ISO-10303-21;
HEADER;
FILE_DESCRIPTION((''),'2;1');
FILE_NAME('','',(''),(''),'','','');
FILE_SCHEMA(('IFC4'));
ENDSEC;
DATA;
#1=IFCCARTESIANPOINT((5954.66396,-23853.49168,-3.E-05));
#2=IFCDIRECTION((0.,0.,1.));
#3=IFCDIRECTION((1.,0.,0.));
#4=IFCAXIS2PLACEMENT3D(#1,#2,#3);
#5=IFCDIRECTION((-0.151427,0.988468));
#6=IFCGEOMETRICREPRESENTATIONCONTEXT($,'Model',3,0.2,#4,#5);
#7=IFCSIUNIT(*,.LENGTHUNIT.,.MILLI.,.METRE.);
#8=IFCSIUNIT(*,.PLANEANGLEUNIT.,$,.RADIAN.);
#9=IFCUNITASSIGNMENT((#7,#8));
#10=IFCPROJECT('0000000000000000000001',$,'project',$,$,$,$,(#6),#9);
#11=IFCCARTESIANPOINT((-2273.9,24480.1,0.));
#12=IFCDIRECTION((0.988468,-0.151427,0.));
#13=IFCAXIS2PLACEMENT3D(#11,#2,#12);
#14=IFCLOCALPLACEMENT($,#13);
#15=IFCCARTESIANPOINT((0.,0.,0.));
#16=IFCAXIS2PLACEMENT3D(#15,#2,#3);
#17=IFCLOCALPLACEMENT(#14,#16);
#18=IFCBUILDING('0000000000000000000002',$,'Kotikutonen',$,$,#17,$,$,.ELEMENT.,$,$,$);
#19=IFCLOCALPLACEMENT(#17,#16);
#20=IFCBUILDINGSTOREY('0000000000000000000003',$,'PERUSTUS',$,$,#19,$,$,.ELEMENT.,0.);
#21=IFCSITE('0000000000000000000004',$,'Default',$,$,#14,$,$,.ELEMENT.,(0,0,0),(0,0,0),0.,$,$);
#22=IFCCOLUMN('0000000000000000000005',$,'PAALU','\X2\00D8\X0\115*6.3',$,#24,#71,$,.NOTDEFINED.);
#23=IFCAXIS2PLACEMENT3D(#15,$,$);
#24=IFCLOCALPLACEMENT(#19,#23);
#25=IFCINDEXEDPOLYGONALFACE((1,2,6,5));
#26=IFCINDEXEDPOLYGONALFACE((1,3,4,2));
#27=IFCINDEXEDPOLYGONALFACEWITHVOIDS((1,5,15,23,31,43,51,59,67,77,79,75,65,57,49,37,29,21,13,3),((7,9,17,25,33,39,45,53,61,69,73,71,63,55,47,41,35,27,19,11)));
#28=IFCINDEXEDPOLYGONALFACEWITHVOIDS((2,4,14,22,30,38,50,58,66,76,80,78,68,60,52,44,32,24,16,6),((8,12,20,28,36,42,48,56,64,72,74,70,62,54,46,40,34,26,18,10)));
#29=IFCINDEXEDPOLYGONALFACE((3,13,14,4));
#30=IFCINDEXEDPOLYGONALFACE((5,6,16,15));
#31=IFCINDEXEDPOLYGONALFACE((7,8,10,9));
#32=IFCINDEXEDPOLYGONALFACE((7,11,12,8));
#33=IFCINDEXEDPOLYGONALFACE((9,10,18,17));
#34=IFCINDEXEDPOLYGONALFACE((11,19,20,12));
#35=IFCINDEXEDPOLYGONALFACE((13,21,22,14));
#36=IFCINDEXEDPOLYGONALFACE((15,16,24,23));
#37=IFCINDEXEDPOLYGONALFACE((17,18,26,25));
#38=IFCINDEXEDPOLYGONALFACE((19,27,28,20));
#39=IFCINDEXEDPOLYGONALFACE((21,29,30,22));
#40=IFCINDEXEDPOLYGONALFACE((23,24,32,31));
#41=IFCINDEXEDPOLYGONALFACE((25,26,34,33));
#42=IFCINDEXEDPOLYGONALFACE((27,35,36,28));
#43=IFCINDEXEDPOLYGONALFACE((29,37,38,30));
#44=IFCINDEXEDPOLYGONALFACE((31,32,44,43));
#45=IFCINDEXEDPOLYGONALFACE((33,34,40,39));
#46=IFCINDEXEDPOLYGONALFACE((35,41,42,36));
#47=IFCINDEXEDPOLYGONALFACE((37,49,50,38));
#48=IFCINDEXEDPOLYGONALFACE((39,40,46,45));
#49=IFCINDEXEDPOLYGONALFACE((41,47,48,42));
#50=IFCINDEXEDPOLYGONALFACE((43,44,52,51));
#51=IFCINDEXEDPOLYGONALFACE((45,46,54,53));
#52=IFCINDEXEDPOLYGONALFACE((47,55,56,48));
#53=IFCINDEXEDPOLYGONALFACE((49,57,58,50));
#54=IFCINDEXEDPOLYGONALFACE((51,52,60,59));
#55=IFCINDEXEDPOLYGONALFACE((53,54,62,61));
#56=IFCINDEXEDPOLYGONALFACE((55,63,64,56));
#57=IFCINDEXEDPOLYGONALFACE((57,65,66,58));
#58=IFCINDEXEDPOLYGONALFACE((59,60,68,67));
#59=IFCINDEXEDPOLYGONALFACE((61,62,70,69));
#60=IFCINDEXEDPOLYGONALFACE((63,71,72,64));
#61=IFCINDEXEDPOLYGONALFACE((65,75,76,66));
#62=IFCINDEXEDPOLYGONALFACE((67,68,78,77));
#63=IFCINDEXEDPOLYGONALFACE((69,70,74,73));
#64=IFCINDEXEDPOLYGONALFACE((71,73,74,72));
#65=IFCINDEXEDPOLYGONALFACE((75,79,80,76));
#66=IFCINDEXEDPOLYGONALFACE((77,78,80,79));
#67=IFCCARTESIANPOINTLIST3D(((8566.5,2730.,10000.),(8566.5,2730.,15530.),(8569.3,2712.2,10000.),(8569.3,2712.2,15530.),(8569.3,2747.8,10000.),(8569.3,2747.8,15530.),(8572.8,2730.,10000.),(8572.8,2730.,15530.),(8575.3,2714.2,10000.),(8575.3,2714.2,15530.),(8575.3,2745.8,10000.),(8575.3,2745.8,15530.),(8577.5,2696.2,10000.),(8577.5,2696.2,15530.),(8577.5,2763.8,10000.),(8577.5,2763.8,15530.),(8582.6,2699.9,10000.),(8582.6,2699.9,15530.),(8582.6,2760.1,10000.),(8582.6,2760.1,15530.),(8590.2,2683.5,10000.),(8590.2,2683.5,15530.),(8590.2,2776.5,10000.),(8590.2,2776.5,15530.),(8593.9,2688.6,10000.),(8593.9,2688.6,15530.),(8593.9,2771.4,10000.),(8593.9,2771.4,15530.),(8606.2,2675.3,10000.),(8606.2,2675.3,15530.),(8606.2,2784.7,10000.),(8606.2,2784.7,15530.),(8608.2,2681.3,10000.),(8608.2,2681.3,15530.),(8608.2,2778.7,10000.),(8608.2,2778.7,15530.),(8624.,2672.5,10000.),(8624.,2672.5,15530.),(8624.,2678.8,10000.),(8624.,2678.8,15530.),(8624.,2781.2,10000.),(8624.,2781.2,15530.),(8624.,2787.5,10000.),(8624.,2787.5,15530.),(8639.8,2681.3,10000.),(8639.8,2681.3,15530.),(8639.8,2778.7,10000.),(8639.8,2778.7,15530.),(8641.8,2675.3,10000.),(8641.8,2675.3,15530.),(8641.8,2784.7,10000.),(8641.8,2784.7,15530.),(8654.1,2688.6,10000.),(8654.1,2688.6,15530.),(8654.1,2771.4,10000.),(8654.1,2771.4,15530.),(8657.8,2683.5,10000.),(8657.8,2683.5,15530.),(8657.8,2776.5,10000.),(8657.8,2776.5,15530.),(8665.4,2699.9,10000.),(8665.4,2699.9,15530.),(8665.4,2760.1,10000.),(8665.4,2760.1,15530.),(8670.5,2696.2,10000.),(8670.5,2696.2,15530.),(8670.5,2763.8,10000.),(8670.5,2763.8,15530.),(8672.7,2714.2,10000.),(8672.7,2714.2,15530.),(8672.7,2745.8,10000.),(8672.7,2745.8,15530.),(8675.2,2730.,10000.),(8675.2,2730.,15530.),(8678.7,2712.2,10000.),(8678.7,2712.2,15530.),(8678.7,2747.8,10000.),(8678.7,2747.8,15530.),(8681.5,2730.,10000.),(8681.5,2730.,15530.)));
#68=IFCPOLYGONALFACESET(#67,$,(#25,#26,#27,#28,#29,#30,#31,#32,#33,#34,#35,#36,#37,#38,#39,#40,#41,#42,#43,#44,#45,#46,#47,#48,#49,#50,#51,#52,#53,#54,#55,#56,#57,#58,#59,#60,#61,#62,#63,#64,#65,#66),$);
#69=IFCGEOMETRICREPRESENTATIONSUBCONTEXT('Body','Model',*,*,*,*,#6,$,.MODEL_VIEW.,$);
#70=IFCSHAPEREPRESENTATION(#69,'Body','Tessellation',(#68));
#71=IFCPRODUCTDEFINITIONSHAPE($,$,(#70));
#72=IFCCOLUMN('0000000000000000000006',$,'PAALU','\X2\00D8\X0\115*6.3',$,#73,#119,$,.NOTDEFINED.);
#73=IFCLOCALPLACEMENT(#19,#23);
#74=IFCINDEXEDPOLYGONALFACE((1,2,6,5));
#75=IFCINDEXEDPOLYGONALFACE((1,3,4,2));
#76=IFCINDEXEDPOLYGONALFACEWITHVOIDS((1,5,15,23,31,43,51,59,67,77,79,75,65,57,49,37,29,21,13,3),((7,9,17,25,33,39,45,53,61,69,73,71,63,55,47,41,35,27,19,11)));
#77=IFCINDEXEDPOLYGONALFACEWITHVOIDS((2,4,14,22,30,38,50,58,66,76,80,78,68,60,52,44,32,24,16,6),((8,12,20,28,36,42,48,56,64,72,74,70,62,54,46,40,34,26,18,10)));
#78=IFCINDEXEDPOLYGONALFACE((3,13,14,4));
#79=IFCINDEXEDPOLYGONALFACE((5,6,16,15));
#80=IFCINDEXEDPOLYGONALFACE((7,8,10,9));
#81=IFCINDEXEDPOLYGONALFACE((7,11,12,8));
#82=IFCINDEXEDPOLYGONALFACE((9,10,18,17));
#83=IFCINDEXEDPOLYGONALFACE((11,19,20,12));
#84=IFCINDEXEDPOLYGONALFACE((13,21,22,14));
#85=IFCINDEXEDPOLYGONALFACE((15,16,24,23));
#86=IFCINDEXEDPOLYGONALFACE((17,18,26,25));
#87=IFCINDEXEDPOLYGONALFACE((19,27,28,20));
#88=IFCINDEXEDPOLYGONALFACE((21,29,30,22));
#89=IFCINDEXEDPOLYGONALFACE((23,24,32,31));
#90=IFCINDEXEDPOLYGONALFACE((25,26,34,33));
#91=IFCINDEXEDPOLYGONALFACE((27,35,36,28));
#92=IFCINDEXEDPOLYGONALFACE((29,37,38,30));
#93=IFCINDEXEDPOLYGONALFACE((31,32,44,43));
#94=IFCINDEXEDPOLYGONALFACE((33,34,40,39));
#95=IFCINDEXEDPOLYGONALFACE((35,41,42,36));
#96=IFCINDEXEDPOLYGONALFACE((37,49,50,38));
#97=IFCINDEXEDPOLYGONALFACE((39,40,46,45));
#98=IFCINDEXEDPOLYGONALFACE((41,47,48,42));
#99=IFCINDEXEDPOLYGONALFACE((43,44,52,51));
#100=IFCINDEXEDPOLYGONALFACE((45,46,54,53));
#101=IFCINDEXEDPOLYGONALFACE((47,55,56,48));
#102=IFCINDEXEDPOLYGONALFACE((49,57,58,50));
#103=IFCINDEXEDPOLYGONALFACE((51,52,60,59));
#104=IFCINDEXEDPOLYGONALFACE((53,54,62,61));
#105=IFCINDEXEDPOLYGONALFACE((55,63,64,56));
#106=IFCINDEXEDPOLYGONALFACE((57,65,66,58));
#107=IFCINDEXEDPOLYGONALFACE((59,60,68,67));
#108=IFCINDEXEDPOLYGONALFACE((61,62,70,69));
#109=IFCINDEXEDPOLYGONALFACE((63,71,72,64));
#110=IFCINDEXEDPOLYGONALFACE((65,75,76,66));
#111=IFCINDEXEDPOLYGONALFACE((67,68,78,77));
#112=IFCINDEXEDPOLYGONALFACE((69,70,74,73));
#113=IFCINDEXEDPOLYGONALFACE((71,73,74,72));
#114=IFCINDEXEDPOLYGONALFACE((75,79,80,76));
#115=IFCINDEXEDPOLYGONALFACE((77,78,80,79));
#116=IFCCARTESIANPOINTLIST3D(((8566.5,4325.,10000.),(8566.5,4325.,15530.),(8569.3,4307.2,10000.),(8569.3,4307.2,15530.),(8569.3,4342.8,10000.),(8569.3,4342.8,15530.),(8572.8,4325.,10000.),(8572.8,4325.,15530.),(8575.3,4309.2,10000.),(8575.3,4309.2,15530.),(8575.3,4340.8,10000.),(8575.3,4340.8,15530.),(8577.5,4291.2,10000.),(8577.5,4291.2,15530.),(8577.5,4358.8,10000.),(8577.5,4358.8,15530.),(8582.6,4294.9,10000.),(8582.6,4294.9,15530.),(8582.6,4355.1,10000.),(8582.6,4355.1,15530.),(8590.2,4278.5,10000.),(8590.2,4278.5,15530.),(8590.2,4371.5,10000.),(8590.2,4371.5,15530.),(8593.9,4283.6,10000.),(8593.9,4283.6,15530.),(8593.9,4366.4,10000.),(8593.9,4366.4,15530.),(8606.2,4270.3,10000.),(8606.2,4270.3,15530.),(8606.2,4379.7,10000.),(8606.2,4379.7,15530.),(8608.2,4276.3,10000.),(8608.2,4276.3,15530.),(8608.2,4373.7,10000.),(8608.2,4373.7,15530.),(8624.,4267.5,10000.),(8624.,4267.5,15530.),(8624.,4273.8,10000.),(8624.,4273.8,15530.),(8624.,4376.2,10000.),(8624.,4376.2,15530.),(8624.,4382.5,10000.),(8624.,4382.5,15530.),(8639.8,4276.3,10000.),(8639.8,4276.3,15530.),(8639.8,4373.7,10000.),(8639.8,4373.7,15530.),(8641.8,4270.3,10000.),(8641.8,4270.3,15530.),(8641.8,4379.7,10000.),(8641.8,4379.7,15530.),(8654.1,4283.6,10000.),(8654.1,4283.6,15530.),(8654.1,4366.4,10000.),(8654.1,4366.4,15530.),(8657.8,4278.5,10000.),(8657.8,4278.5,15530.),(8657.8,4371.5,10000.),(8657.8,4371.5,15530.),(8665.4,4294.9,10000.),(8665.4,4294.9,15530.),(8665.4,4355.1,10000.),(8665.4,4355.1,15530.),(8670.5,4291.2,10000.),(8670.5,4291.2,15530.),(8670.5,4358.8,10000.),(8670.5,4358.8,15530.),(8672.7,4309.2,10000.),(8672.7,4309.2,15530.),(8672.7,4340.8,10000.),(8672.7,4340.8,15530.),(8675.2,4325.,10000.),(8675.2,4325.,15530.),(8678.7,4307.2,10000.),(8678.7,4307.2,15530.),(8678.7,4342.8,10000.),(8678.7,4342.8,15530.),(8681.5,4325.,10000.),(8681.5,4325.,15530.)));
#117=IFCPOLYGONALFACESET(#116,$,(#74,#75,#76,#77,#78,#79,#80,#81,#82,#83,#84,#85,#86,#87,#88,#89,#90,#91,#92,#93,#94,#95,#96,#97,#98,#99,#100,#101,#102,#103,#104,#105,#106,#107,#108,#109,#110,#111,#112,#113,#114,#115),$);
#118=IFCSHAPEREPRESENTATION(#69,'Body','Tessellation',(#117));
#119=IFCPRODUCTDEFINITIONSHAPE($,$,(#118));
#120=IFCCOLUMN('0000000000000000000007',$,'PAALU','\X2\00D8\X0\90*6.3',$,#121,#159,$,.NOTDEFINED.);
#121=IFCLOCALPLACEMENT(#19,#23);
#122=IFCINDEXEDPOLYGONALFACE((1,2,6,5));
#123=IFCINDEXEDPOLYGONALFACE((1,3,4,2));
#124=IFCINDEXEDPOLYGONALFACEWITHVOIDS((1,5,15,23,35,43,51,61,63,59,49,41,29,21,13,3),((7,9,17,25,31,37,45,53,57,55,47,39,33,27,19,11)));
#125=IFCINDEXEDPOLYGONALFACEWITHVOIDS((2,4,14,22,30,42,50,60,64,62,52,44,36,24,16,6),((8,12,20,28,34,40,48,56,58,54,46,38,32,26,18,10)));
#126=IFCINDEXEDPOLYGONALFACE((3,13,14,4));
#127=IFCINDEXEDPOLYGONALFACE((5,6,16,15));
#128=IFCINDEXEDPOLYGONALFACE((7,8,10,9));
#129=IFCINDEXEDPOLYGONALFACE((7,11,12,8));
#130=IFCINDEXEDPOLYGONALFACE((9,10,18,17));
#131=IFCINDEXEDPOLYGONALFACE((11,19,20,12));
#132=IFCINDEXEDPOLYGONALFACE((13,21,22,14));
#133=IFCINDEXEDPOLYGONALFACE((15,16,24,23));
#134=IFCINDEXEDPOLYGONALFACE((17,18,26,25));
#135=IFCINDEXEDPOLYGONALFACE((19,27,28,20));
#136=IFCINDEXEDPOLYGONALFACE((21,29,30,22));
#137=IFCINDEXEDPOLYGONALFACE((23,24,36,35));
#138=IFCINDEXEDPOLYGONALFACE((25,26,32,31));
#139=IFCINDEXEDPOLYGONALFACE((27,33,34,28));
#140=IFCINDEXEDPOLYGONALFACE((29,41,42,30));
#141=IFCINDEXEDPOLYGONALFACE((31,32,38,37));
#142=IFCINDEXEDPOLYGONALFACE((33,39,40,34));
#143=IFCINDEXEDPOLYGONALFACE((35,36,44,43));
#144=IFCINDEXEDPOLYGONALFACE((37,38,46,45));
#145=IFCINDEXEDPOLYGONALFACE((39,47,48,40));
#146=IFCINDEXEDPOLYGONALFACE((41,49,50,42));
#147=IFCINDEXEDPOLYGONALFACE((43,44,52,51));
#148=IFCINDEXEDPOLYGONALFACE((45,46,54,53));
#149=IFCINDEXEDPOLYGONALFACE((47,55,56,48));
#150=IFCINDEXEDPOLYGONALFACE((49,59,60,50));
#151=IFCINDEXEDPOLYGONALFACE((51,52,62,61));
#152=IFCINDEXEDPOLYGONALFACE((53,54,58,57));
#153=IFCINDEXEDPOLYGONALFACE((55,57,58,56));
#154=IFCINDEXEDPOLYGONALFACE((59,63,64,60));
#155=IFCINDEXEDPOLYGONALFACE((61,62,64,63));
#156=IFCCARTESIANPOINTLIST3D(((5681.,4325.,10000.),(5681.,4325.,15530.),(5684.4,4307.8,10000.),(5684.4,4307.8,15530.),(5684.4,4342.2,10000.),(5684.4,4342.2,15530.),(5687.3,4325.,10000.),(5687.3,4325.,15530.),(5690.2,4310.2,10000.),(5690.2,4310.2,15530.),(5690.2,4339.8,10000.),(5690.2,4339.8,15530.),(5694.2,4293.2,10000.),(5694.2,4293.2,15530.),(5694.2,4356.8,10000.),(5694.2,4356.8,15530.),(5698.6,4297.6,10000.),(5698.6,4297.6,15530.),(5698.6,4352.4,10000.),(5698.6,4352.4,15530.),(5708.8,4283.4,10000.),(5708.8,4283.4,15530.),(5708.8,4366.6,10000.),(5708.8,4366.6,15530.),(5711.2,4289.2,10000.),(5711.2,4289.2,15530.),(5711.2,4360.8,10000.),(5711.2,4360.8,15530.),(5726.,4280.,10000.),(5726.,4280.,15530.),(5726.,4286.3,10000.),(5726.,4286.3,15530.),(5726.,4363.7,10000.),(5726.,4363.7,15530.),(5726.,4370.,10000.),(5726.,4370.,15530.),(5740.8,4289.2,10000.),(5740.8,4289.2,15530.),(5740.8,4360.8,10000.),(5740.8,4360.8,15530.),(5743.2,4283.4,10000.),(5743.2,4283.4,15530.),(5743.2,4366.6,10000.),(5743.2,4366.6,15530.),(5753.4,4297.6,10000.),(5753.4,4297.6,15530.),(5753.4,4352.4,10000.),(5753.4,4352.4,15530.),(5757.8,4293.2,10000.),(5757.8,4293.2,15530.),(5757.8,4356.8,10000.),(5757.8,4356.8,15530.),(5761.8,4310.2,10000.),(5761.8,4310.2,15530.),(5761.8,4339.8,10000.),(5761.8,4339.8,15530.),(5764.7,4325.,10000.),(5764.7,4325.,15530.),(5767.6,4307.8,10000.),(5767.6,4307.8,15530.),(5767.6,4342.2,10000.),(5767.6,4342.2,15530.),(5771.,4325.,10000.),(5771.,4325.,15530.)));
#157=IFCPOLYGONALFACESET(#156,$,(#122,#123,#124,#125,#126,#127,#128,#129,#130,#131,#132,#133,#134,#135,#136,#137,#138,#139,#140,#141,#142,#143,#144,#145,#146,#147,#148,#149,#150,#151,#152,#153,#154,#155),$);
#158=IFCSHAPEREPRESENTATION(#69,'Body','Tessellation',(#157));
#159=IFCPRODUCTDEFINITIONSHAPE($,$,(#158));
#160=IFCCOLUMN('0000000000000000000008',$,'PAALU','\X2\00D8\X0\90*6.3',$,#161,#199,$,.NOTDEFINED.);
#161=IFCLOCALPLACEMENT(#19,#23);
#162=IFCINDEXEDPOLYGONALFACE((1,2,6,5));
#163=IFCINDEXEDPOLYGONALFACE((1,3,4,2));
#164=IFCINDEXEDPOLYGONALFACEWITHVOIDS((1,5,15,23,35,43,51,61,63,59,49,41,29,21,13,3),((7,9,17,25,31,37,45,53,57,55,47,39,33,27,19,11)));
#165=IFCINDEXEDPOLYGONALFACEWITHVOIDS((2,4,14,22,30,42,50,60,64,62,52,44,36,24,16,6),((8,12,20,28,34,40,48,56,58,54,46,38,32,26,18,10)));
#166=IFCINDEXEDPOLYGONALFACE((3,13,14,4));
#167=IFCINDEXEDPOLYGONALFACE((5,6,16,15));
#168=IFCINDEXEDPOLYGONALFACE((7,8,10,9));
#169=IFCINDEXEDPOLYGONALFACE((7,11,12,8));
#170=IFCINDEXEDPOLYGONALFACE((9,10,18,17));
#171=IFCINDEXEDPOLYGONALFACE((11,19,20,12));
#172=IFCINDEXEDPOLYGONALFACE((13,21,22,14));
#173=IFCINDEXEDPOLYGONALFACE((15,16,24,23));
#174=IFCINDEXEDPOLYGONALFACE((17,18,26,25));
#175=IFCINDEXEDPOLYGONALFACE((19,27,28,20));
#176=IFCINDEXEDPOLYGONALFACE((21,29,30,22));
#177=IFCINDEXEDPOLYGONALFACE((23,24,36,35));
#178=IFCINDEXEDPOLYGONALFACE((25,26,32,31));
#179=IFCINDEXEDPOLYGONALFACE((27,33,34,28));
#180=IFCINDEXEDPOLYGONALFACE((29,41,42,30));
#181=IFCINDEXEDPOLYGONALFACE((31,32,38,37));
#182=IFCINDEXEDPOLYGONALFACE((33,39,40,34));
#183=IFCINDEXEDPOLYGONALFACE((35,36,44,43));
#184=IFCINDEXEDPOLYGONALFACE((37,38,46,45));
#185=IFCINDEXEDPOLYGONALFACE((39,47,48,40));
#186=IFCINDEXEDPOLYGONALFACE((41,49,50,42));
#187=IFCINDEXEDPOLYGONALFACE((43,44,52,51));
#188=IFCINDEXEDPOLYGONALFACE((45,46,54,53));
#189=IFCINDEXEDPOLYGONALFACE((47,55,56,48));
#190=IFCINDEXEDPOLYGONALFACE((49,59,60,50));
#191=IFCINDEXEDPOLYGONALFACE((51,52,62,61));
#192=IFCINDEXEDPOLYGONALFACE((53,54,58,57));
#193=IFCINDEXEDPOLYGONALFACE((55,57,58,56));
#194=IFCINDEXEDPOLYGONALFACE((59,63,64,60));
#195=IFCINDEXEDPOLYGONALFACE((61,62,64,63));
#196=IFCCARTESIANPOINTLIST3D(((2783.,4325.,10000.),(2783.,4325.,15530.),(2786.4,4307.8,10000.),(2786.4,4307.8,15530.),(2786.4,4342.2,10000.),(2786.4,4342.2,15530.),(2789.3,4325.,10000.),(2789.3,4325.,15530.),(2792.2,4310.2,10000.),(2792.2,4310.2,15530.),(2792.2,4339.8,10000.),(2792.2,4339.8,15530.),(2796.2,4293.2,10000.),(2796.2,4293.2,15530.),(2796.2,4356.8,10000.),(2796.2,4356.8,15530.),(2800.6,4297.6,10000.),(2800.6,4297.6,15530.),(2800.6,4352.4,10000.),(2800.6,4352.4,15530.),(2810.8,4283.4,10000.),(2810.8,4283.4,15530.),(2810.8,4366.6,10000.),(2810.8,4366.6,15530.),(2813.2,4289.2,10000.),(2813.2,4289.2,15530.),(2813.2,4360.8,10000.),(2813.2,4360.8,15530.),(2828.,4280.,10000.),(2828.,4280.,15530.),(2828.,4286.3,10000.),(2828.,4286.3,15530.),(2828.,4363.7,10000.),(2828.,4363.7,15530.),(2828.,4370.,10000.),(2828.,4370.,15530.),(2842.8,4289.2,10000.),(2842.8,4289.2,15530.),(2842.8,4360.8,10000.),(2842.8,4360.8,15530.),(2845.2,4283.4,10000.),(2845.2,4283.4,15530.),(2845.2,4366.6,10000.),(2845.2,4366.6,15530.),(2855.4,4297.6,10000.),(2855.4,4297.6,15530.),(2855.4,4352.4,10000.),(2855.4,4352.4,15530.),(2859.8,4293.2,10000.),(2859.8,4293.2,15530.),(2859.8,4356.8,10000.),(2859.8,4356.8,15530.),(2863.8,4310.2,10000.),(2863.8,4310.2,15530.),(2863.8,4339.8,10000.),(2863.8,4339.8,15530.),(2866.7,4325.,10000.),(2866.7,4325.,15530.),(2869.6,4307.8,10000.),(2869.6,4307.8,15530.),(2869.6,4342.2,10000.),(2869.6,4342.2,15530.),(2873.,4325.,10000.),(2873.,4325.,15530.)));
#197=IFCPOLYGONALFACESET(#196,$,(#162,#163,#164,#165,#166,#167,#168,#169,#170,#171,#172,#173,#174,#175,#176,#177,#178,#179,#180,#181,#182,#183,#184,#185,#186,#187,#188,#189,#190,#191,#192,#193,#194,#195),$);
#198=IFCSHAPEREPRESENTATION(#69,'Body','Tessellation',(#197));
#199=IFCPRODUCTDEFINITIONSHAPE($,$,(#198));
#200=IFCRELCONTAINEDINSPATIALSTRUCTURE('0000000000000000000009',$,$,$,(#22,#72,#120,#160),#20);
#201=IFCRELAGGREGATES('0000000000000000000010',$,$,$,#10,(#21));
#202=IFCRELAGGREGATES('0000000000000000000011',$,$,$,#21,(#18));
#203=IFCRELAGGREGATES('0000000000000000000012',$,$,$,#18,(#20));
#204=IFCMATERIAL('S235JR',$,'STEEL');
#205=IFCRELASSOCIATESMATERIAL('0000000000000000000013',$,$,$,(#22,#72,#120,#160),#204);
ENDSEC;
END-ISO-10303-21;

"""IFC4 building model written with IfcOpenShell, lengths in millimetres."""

from ifc_helpers import new_model, si_unit, direction, frame, origin_with_axes, place, context, subcontext, project, spatial, line, indexed_curve, outline, extrude, material, element, save


model = new_model("IFC4")

# Units and contexts
model_context = context("Model", 3, precision=0.2, world=frame((5954.66396, -23853.49168, -3e-05), z_axis=(0.0, 0.0, 1.0), x_axis=(1.0, 0.0, 0.0)), true_north=direction((-0.151427, 0.988468)))
body_context = subcontext(model_context, "Body", "Model", "MODEL_VIEW")
ifc_project = project(units=[si_unit("LENGTHUNIT", "METRE", prefix="MILLI"), si_unit("PLANEANGLEUNIT", "RADIAN")], contexts=[model_context])

# Site, building, storey
site_placement = place(None, frame((-2273.9, 24480.1, 0.0), z_axis=(0.0, 0.0, 1.0), x_axis=(0.988468, -0.151427, 0.0)))
site = spatial("IfcSite", under=ifc_project, at=site_placement, Name="Default", CompositionType="ELEMENT", RefLatitude=(0, 0, 0), RefLongitude=(0, 0, 0), RefElevation=0.0)
building_placement = place(site_placement, origin_with_axes())
building = spatial("IfcBuilding", under=site, at=building_placement, Name="Kotikutonen", CompositionType="ELEMENT")
storey_placement = place(building_placement, origin_with_axes())
storey = spatial("IfcBuildingStorey", under=building, at=storey_placement, Name="PERUSTUS", CompositionType="ELEMENT", Elevation=0.0)

# Columns
ifc_material = material(Name="S235JR", Category="STEEL")
for number, where, z_axis, x_axis, name in (
    (1, (8624.0, 2730.0, 10000.0), (-1.0, 0.0, 0.0), (0.0, 0.0, 1.0), "PAALU"),
    (2, (8624.0, 4325.0, 10000.0), (-1.0, 0.0, 0.0), (0.0, 0.0, 1.0), "PAALU"),
):
    element("IfcColumn", number, at=place(storey_placement, frame(where, z_axis=z_axis, x_axis=x_axis)), inside=storey, material=ifc_material, Name=name, Description="Ø115*6.3", PredefinedType="NOTDEFINED", context=body_context, shape_type="SolidModel", body=[
        extrude(outline(indexed_curve([(57.5, 0.0), (54.7, 17.8), (46.5, 33.8), (33.8, 46.5), (17.8, 54.7), (0.0, 57.5), (-17.8, 54.7), (-33.8, 46.5), (-46.5, 33.8), (-54.7, 17.8), (-57.5, 0.0), (-54.7, -17.8), (-46.5, -33.8), (-33.8, -46.5), (-17.8, -54.7), (0.0, -57.5), (17.8, -54.7), (33.8, -46.5), (46.5, -33.8), (54.7, -17.8)], segments=[line(1, 2, 3, 4, 5, 6, 7, 8, 9, 10, 11, 12, 13, 14, 15, 16, 17, 18, 19, 20, 1)]), holes=[indexed_curve([(51.2, 0.0), (48.7, -15.8), (41.4, -30.1), (30.1, -41.4), (15.8, -48.7), (0.0, -51.2), (-15.8, -48.7), (-30.1, -41.4), (-41.4, -30.1), (-48.7, -15.8), (-51.2, 0.0), (-48.7, 15.8), (-41.4, 30.1), (-30.1, 41.4), (-15.8, 48.7), (0.0, 51.2), (15.8, 48.7), (30.1, 41.4), (41.4, 30.1), (48.7, 15.8)], segments=[line(1, 2, 3, 4, 5, 6, 7, 8, 9, 10, 11, 12, 13, 14, 15, 16, 17, 18, 19, 20, 1)])]), frame((0.0, 0.0, 0.0), z_axis=(-1.0, 0.0, 0.0), x_axis=(0.0, 0.0, 1.0)), (0.0, 0.0, -1.0), 5530.0),
    ])
for number, where, z_axis, x_axis, name in (
    (3, (5726.0, 4325.0, 10000.0), (-1.0, 0.0, 0.0), (0.0, 0.0, 1.0), "PAALU"),
    (4, (2828.0, 4325.0, 10000.0), (-1.0, 0.0, 0.0), (0.0, 0.0, 1.0), "PAALU"),
):
    element("IfcColumn", number, at=place(storey_placement, frame(where, z_axis=z_axis, x_axis=x_axis)), inside=storey, material=ifc_material, Name=name, Description="Ø90*6.3", PredefinedType="NOTDEFINED", context=body_context, shape_type="SolidModel", body=[
        extrude(outline(indexed_curve([(45.0, 0.0), (41.6, 17.2), (31.8, 31.8), (17.2, 41.6), (0.0, 45.0), (-17.2, 41.6), (-31.8, 31.8), (-41.6, 17.2), (-45.0, 0.0), (-41.6, -17.2), (-31.8, -31.8), (-17.2, -41.6), (0.0, -45.0), (17.2, -41.6), (31.8, -31.8), (41.6, -17.2)], segments=[line(1, 2, 3, 4, 5, 6, 7, 8, 9, 10, 11, 12, 13, 14, 15, 16, 1)]), holes=[indexed_curve([(38.7, 0.0), (35.8, -14.8), (27.4, -27.4), (14.8, -35.8), (0.0, -38.7), (-14.8, -35.8), (-27.4, -27.4), (-35.8, -14.8), (-38.7, 0.0), (-35.8, 14.8), (-27.4, 27.4), (-14.8, 35.8), (0.0, 38.7), (14.8, 35.8), (27.4, 27.4), (35.8, 14.8)], segments=[line(1, 2, 3, 4, 5, 6, 7, 8, 9, 10, 11, 12, 13, 14, 15, 16, 1)])]), frame((0.0, 0.0, 0.0), z_axis=(-1.0, 0.0, 0.0), x_axis=(0.0, 0.0, 1.0)), (0.0, 0.0, -1.0), 5530.0),
    ])

save(model, "model.ifc")
